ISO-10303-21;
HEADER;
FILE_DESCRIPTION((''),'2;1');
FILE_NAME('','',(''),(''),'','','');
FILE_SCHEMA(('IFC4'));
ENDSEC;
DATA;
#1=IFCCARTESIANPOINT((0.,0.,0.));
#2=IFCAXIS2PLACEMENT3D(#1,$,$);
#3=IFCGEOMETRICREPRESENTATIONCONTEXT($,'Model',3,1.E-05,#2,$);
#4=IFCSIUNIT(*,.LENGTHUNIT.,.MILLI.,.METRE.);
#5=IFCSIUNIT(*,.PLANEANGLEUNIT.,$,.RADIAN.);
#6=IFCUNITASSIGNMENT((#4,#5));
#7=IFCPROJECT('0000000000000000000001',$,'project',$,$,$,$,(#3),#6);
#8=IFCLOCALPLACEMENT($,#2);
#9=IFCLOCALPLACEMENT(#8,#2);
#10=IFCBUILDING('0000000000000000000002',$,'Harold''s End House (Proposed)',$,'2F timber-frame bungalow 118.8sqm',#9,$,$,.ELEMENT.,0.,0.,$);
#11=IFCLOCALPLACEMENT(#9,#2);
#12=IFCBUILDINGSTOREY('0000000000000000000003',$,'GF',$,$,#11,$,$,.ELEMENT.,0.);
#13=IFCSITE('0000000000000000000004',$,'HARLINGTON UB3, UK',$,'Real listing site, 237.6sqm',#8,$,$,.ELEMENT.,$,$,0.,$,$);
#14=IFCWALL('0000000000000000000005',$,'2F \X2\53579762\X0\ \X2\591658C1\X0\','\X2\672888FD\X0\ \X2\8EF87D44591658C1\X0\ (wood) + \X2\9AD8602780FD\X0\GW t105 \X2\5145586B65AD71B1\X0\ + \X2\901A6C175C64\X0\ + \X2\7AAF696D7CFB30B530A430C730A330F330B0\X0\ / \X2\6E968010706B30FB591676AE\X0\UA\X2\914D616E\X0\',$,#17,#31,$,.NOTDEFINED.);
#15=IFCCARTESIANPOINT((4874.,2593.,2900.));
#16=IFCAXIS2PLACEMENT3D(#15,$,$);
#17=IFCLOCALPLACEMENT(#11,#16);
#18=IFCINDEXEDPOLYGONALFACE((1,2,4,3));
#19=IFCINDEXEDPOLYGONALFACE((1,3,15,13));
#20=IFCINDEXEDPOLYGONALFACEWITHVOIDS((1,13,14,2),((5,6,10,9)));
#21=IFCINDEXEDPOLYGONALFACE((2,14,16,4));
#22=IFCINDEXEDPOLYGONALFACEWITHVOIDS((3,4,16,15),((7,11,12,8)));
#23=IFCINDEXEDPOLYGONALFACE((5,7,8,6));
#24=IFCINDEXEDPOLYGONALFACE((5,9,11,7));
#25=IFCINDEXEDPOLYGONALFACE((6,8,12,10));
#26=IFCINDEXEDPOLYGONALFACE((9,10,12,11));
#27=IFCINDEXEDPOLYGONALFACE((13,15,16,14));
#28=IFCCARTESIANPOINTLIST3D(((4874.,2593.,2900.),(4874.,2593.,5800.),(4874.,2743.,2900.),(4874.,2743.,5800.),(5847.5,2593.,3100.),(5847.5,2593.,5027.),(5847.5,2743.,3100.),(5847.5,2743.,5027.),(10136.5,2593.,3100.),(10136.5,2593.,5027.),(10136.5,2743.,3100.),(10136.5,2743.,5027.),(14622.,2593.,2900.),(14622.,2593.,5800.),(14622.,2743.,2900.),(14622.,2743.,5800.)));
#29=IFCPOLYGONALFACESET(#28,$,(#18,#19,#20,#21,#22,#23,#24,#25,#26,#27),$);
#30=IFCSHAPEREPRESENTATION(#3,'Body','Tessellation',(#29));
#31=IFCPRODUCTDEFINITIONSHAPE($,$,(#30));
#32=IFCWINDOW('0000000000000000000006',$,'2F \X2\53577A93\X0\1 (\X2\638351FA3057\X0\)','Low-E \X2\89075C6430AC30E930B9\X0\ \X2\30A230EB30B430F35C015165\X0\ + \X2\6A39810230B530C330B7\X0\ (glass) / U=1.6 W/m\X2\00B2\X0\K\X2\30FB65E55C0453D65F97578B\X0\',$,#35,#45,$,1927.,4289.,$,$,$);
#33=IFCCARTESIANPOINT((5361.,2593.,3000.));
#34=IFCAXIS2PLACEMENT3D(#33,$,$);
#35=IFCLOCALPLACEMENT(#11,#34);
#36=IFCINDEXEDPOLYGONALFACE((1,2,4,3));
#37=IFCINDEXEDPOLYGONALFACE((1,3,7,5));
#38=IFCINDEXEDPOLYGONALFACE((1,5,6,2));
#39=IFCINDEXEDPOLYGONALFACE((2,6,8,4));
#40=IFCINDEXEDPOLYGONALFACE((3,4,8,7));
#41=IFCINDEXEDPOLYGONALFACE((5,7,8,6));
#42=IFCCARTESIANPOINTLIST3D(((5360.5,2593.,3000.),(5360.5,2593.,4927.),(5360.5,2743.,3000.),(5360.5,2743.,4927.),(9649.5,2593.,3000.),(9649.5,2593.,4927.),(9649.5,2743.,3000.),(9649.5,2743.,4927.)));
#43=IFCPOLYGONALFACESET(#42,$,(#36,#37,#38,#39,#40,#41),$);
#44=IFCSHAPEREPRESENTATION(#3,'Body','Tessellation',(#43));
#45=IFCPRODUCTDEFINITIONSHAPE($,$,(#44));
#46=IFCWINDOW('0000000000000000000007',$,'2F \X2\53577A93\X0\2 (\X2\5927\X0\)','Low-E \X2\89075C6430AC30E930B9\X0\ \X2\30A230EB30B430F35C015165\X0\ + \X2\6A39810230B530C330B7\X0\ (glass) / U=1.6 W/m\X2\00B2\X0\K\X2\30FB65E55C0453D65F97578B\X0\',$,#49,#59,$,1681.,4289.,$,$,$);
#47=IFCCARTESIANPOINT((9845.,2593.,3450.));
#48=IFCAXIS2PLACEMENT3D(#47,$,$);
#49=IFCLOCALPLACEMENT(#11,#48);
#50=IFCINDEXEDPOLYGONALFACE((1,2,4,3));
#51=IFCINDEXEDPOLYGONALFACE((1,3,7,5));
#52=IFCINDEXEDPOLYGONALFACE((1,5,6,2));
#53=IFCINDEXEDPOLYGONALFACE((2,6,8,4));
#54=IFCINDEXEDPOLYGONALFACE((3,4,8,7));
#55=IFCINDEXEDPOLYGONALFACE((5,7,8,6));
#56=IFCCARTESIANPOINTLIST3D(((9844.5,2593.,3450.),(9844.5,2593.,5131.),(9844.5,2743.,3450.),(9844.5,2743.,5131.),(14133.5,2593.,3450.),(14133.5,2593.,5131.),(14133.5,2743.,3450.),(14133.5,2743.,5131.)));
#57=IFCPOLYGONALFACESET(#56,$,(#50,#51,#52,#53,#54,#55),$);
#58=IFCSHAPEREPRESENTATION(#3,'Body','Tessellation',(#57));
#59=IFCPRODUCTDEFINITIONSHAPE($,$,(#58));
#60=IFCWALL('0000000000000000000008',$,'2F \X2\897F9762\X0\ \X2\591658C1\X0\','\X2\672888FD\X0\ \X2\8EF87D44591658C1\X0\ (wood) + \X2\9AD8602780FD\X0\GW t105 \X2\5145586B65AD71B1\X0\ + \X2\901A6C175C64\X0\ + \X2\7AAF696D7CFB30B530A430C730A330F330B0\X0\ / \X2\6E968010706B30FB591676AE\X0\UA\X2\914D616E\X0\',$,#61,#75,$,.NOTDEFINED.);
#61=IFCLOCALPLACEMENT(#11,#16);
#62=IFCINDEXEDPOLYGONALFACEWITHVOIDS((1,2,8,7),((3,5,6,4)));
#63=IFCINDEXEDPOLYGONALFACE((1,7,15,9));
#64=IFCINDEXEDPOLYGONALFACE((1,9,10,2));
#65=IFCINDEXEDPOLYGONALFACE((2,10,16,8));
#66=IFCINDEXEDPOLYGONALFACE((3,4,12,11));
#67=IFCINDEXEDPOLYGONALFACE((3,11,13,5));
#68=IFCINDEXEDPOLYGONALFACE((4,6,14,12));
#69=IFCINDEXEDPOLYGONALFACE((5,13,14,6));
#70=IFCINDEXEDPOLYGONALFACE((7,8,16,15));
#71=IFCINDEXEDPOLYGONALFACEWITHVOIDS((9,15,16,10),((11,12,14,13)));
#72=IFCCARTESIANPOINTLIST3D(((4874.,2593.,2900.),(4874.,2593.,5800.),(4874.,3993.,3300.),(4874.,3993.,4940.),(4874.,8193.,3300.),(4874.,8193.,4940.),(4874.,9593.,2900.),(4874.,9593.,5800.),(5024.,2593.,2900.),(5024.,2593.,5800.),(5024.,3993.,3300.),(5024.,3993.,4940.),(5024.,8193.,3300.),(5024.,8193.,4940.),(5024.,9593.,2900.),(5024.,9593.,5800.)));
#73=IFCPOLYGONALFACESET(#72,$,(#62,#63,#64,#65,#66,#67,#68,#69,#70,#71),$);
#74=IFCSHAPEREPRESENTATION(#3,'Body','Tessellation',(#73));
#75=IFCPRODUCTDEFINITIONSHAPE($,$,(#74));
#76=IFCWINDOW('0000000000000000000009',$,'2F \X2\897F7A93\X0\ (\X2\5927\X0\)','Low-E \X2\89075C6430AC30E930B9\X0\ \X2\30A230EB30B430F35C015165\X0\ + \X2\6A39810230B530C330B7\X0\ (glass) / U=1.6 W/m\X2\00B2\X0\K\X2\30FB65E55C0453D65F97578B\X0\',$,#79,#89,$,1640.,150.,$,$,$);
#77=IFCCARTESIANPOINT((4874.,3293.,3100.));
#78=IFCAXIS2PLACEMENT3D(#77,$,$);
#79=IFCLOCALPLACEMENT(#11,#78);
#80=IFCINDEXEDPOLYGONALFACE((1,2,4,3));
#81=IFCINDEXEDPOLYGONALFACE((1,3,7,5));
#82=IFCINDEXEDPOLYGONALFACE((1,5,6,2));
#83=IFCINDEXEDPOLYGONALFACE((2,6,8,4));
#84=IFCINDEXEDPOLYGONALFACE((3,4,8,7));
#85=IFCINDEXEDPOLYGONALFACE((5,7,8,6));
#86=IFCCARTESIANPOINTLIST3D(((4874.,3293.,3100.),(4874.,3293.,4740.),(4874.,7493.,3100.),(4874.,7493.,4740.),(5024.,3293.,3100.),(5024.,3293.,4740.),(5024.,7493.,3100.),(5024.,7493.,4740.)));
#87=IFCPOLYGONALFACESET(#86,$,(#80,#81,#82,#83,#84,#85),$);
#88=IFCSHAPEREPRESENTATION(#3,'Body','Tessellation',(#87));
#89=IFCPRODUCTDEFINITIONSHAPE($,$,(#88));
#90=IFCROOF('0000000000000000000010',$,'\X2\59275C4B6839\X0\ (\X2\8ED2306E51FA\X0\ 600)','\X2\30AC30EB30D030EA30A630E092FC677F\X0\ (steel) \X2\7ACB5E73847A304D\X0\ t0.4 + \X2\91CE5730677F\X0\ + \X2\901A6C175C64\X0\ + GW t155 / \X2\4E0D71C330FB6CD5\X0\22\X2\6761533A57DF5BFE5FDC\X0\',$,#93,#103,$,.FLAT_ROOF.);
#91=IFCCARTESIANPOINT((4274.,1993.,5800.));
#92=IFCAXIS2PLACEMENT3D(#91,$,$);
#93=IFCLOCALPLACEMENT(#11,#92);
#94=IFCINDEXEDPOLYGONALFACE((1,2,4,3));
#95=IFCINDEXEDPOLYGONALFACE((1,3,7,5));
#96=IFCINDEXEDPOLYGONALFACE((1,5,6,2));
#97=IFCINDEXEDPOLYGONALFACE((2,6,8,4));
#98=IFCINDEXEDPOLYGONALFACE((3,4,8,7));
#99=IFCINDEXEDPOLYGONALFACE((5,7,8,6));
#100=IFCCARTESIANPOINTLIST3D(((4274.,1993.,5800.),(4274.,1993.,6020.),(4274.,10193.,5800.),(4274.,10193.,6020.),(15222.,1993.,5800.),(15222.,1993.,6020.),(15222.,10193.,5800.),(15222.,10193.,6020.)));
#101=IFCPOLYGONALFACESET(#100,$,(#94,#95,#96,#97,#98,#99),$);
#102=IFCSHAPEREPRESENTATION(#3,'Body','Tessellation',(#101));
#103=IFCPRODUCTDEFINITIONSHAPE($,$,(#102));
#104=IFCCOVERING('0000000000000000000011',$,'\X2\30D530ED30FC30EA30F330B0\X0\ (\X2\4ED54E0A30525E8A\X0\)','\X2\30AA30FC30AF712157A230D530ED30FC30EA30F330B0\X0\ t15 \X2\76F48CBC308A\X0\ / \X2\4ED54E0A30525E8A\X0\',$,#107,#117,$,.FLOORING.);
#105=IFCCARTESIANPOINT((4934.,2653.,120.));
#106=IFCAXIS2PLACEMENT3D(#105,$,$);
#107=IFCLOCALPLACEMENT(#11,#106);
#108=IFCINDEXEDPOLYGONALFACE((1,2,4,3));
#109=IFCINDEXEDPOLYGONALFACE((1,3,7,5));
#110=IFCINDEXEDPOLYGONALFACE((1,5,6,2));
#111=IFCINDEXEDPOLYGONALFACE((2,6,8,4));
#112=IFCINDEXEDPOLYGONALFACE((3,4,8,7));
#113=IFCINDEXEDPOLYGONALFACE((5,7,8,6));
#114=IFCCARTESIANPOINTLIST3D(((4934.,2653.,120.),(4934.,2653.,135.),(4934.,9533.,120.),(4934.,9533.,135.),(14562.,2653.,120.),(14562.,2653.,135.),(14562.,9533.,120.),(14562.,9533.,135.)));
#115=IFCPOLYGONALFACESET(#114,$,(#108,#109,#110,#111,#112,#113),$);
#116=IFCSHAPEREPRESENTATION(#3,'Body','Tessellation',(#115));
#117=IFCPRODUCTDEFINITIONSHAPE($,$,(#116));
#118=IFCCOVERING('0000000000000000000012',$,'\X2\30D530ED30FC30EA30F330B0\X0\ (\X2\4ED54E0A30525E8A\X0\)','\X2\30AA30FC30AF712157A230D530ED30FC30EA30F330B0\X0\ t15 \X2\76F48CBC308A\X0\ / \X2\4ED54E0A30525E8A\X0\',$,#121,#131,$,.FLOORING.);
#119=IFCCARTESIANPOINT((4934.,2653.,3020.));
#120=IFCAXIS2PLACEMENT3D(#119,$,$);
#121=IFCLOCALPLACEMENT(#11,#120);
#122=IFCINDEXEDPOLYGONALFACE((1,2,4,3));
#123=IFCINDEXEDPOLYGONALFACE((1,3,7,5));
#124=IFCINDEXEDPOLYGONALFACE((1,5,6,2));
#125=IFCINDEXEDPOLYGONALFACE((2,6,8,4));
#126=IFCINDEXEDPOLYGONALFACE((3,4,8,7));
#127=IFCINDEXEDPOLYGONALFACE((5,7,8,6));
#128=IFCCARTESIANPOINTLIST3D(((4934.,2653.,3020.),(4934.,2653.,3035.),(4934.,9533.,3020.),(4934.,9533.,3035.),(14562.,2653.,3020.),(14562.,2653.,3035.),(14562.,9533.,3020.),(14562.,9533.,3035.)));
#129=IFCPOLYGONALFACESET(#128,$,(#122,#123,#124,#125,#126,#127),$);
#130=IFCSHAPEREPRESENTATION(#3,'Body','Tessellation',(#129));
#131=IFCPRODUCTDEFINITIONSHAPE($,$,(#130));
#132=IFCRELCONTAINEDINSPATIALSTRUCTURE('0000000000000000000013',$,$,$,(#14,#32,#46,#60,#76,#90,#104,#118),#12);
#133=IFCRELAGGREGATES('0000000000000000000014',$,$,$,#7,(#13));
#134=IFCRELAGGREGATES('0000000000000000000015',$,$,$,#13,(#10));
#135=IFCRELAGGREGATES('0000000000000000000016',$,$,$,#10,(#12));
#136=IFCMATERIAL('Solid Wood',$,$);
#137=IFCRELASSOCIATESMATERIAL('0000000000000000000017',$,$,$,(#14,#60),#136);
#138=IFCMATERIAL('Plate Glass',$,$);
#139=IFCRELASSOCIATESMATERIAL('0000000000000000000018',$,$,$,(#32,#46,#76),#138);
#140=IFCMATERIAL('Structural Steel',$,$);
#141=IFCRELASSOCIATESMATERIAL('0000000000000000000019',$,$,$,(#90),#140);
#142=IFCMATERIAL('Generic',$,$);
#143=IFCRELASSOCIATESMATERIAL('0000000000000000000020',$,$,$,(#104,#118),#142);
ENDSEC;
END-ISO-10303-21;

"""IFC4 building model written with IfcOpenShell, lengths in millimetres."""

from ifc_helpers import new_model, si_unit, frame, frame_2d, origin, place, context, project, spatial, rectangle, extrude, material, element, fill, save


model = new_model("IFC4")

# Units and contexts
model_context = context("Model", 3, precision=1e-05, world=origin())
ifc_project = project(units=[si_unit("LENGTHUNIT", "METRE", prefix="MILLI"), si_unit("PLANEANGLEUNIT", "RADIAN")], contexts=[model_context])

# Site, building, storey
site_placement = place(None, origin())
site = spatial("IfcSite", under=ifc_project, at=site_placement, Name="HARLINGTON UB3, UK", ObjectType="Real listing site, 237.6sqm", CompositionType="ELEMENT", RefElevation=0.0)
building_placement = place(site_placement, origin())
building = spatial("IfcBuilding", under=site, at=building_placement, Name="Harold's End House (Proposed)", ObjectType="2F timber-frame bungalow 118.8sqm", CompositionType="ELEMENT", ElevationOfRefHeight=0.0, ElevationOfTerrain=0.0)
storey_placement = place(building_placement, origin())
storey = spatial("IfcBuildingStorey", under=building, at=storey_placement, Name="GF", CompositionType="ELEMENT", Elevation=0.0)

# Shared definitions
ifc_material_1 = material(Name="Solid Wood")

# Shared definitions
ifc_material_2 = material(Name="Plate Glass")

# Wall, openings, windows
wall_1_placement = place(storey_placement, frame((4874.0, 2593.0, 2900.0)))
wall_1 = element("IfcWall", 1, at=wall_1_placement, inside=storey, material=ifc_material_1, Name="2F 南面 外壁", Description="木製 軸組外壁 (wood) + 高性能GW t105 充填断熱 + 通気層 + 窯業系サイディング / 準耐火・外皮UA配慮", PredefinedType="NOTDEFINED", context=model_context, shape_type="SweptSolid", body=[
    extrude(rectangle(XDim=9748.0, YDim=150.0, at=frame_2d((4874.0, 75.0))), frame((4874.0, 2593.0, 2900.0)), (0.0, 0.0, 1.0), 2900.0),
])
opening_1_placement = place(storey_placement, frame((5361.0, 2593.0, 3000.0)))
opening_1 = element("IfcOpeningElement", 2, at=opening_1_placement, cuts=wall_1, PredefinedType="NOTDEFINED", context=model_context, shape_type="SweptSolid", body=[
    extrude(rectangle(XDim=4289.0, YDim=150.0, at=frame_2d((2144.0, 75.0))), frame((5361.0, 2593.0, 3000.0)), (0.0, 0.0, 1.0), 1927.0),
])
opening_2_placement = place(storey_placement, frame((9845.0, 2593.0, 3450.0)))
opening_2 = element("IfcOpeningElement", 3, at=opening_2_placement, cuts=wall_1, PredefinedType="NOTDEFINED", context=model_context, shape_type="SweptSolid", body=[
    extrude(rectangle(XDim=4289.0, YDim=150.0, at=frame_2d((2144.0, 75.0))), frame((9845.0, 2593.0, 3450.0)), (0.0, 0.0, 1.0), 1681.0),
])
window_1_placement = place(storey_placement, frame((5361.0, 2593.0, 3000.0)))
window_1 = element("IfcWindow", 4, at=window_1_placement, inside=storey, material=ifc_material_2, Name="2F 南窓1 (掃出し)", Description="Low-E 複層ガラス アルゴン封入 + 樹脂サッシ (glass) / U=1.6 W/m²K・日射取得型", OverallHeight=1927.0, OverallWidth=4289.0, context=model_context, shape_type="SweptSolid", body=[
    extrude(rectangle(XDim=4289.0, YDim=150.0, at=frame_2d((2144.0, 75.0))), frame((5361.0, 2593.0, 3000.0)), (0.0, 0.0, 1.0), 1927.0),
])
fill(opening_1, window_1)
window_2_placement = place(storey_placement, frame((9845.0, 2593.0, 3450.0)))
window_2 = element("IfcWindow", 5, at=window_2_placement, inside=storey, material=ifc_material_2, Name="2F 南窓2 (大)", Description="Low-E 複層ガラス アルゴン封入 + 樹脂サッシ (glass) / U=1.6 W/m²K・日射取得型", OverallHeight=1681.0, OverallWidth=4289.0, context=model_context, shape_type="SweptSolid", body=[
    extrude(rectangle(XDim=4289.0, YDim=150.0, at=frame_2d((2144.0, 75.0))), frame((9845.0, 2593.0, 3450.0)), (0.0, 0.0, 1.0), 1681.0),
])
fill(opening_2, window_2)

# Wall, opening, window
wall_2_placement = place(storey_placement, frame((4874.0, 2593.0, 2900.0)))
wall_2 = element("IfcWall", 6, at=wall_2_placement, inside=storey, material=ifc_material_1, Name="2F 西面 外壁", Description="木製 軸組外壁 (wood) + 高性能GW t105 充填断熱 + 通気層 + 窯業系サイディング / 準耐火・外皮UA配慮", PredefinedType="NOTDEFINED", context=model_context, shape_type="SweptSolid", body=[
    extrude(rectangle(XDim=150.0, YDim=7000.0, at=frame_2d((75.0, 3500.0))), frame((4874.0, 2593.0, 2900.0)), (0.0, 0.0, 1.0), 2900.0),
])
opening_3_placement = place(storey_placement, frame((4874.0, 3293.0, 3100.0)))
opening_3 = element("IfcOpeningElement", 7, at=opening_3_placement, cuts=wall_2, PredefinedType="NOTDEFINED", context=model_context, shape_type="SweptSolid", body=[
    extrude(rectangle(XDim=150.0, YDim=4200.0, at=frame_2d((75.0, 2100.0))), frame((4874.0, 3293.0, 3100.0)), (0.0, 0.0, 1.0), 1640.0),
])
window_3_placement = place(storey_placement, frame((4874.0, 3293.0, 3100.0)))
window_3 = element("IfcWindow", 8, at=window_3_placement, inside=storey, material=ifc_material_2, Name="2F 西窓 (大)", Description="Low-E 複層ガラス アルゴン封入 + 樹脂サッシ (glass) / U=1.6 W/m²K・日射取得型", OverallHeight=1640.0, OverallWidth=150.0, context=model_context, shape_type="SweptSolid", body=[
    extrude(rectangle(XDim=150.0, YDim=4200.0, at=frame_2d((75.0, 2100.0))), frame((4874.0, 3293.0, 3100.0)), (0.0, 0.0, 1.0), 1640.0),
])
fill(opening_3, window_3)

# Roof
ifc_material_3 = material(Name="Structural Steel")
roof_placement = place(storey_placement, frame((4274.0, 1993.0, 5800.0)))
element("IfcRoof", 9, at=roof_placement, inside=storey, material=ifc_material_3, Name="大屋根 (軒の出 600)", Description="ガルバリウム鋼板 (steel) 立平葺き t0.4 + 野地板 + 通気層 + GW t155 / 不燃・法22条区域対応", PredefinedType="FLAT_ROOF", context=model_context, shape_type="SweptSolid", body=[
    extrude(rectangle(XDim=10948.0, YDim=8200.0, at=frame_2d((5474.0, 4100.0))), frame((4274.0, 1993.0, 5800.0)), (0.0, 0.0, 1.0), 220.0),
])

# Coverings
ifc_material_4 = material(Name="Generic")
covering_1_placement = place(storey_placement, frame((4934.0, 2653.0, 120.0)))
element("IfcCovering", 10, at=covering_1_placement, inside=storey, material=ifc_material_4, Name="フローリング (仕上げ床)", Description="オーク無垢フローリング t15 直貼り / 仕上げ床", PredefinedType="FLOORING", context=model_context, shape_type="SweptSolid", body=[
    extrude(rectangle(XDim=9628.0, YDim=6880.0, at=frame_2d((4814.0, 3440.0))), frame((4934.0, 2653.0, 120.0)), (0.0, 0.0, 1.0), 15.0),
])
covering_2_placement = place(storey_placement, frame((4934.0, 2653.0, 3020.0)))
element("IfcCovering", 11, at=covering_2_placement, inside=storey, material=ifc_material_4, Name="フローリング (仕上げ床)", Description="オーク無垢フローリング t15 直貼り / 仕上げ床", PredefinedType="FLOORING", context=model_context, shape_type="SweptSolid", body=[
    extrude(rectangle(XDim=9628.0, YDim=6880.0, at=frame_2d((4814.0, 3440.0))), frame((4934.0, 2653.0, 3020.0)), (0.0, 0.0, 1.0), 15.0),
])

save(model, "model.ifc")
